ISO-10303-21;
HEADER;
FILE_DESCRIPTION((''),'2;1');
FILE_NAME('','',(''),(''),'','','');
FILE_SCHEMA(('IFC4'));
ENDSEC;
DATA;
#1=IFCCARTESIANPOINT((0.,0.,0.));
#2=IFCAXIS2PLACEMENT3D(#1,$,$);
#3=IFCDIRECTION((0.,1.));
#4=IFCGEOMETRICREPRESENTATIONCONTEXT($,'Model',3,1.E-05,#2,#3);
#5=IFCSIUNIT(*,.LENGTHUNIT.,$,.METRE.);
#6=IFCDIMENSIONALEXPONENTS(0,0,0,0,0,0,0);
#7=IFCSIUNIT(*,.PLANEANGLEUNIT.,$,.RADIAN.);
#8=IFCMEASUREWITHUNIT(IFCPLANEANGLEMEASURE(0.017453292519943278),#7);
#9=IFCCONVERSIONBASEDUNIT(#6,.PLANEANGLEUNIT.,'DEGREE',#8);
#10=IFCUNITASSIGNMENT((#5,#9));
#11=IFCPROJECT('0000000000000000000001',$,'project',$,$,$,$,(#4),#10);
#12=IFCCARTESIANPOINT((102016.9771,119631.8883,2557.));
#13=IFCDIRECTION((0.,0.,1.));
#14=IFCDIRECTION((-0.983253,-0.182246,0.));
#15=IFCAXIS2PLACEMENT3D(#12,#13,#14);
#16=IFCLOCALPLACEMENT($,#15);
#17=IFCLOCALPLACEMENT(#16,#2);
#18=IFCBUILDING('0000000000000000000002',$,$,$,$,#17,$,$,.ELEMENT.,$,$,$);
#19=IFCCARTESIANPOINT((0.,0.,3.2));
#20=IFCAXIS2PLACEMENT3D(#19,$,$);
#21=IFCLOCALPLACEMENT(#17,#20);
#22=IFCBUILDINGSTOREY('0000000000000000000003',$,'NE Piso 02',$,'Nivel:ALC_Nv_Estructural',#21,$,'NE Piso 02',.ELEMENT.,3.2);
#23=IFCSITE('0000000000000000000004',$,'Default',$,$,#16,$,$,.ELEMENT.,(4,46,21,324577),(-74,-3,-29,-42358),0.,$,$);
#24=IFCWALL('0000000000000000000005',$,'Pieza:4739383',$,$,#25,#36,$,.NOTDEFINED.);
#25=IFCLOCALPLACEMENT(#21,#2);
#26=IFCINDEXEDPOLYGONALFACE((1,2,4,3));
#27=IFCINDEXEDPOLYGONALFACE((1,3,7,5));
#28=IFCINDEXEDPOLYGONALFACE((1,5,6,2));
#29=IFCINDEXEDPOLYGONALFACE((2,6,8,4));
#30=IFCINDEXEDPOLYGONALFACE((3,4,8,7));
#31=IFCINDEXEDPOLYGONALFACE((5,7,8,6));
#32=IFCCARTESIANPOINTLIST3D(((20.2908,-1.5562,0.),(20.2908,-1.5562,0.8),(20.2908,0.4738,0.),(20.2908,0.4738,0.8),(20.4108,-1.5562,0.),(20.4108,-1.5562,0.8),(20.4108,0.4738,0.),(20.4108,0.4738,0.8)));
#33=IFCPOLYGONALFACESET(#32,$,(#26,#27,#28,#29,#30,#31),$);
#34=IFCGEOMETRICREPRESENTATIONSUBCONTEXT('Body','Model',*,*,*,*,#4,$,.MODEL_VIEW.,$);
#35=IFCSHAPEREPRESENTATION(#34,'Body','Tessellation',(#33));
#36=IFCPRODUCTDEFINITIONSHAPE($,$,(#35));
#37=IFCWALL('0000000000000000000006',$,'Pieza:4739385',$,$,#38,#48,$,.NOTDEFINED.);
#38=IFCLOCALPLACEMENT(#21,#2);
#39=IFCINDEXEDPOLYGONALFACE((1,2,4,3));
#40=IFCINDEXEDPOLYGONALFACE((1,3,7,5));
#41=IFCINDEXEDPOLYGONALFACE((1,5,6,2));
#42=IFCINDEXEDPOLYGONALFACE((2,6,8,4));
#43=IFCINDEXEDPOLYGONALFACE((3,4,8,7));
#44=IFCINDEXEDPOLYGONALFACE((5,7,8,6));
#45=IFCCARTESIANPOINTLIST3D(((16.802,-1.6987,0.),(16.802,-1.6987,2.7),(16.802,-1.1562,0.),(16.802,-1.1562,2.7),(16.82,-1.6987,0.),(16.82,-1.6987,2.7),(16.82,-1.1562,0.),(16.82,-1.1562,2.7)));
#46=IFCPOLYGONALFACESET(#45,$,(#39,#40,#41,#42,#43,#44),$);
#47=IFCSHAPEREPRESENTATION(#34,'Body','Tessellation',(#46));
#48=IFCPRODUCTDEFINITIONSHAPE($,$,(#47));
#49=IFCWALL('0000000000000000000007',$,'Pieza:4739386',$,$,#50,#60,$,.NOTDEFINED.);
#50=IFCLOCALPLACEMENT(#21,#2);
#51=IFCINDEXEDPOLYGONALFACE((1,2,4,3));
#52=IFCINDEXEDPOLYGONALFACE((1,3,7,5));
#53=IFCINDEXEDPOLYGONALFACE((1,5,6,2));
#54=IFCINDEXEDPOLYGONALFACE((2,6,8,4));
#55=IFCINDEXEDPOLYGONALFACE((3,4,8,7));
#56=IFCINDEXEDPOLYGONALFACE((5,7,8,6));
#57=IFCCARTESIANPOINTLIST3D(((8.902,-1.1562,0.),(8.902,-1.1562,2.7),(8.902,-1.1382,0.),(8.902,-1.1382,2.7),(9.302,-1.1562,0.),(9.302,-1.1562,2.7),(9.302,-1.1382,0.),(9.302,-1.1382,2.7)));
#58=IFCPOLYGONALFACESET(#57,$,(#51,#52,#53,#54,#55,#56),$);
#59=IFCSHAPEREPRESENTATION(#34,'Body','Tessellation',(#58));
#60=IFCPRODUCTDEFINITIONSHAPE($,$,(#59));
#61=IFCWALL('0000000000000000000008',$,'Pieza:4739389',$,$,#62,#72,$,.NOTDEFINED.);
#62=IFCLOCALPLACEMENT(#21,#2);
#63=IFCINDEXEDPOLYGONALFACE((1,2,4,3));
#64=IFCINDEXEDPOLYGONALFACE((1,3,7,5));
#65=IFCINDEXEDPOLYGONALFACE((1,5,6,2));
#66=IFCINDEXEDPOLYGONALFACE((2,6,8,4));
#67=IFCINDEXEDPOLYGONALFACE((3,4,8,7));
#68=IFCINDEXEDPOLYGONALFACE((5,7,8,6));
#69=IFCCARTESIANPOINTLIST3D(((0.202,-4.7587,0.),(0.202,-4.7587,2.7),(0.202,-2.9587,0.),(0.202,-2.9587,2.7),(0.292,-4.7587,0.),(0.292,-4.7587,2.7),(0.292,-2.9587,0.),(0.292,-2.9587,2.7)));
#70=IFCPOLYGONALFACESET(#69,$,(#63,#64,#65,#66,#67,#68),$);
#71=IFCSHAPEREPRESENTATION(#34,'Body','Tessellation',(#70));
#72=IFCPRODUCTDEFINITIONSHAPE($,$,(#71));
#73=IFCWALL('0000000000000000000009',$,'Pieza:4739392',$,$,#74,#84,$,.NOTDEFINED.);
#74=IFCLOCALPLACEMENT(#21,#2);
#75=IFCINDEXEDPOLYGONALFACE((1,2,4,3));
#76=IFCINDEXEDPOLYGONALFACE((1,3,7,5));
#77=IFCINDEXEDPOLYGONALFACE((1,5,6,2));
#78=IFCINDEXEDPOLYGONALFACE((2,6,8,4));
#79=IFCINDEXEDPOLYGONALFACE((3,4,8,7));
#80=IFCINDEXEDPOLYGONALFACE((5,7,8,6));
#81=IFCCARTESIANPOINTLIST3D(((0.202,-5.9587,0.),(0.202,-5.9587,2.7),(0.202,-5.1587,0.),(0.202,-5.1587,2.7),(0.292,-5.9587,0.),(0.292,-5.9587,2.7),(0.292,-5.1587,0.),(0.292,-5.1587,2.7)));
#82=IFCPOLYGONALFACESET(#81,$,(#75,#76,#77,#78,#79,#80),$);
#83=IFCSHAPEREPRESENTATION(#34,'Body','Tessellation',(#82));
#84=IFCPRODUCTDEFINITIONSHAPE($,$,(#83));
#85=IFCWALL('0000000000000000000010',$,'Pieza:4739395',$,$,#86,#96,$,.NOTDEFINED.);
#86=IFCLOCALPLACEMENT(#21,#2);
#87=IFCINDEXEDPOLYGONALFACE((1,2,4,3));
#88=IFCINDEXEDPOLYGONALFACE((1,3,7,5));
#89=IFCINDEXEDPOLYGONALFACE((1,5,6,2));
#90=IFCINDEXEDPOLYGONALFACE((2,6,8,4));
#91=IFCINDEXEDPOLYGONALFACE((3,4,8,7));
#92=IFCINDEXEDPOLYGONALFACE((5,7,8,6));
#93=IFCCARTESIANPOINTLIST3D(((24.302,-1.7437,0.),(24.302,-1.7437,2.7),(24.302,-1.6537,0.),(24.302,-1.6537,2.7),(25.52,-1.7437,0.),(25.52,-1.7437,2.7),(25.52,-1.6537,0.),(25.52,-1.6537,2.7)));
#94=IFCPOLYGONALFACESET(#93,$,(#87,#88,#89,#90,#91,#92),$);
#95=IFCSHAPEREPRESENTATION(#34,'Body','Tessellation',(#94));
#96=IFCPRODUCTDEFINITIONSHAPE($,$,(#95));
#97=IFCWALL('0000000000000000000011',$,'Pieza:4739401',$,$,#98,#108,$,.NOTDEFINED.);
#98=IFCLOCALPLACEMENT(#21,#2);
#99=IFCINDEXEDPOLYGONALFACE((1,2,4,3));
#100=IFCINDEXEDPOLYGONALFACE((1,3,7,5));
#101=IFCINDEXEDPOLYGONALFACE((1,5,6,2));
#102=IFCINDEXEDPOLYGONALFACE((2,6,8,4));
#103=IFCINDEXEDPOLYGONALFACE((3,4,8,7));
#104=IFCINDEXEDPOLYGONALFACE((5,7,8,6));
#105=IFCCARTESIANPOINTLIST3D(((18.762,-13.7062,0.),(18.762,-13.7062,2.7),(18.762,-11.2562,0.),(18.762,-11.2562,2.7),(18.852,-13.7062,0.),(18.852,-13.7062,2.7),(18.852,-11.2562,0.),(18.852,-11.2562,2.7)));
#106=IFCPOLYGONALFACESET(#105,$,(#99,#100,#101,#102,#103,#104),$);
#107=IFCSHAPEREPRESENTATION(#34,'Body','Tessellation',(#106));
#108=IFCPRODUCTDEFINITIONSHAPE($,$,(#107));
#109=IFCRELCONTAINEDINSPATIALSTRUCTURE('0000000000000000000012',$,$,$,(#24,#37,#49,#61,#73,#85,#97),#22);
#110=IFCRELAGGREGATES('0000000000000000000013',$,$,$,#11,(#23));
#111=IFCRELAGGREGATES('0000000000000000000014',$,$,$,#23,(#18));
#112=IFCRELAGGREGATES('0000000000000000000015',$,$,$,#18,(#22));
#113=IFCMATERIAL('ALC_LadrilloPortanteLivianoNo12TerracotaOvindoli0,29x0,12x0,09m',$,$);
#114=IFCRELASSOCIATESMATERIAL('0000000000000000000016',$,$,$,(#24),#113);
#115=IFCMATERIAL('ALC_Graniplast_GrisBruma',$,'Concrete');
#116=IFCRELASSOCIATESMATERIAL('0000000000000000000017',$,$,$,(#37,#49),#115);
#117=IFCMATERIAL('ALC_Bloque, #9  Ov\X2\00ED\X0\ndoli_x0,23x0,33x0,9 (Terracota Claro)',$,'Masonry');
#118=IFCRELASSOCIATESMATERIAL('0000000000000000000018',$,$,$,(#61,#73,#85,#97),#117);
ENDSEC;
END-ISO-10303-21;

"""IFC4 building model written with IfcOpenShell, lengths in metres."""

from ifc_helpers import new_model, entity, si_unit, converted_unit, direction, frame, frame_2d, origin, origin_2d_with_axis, place, context, subcontext, project, spatial, rectangle, extrude, material, element, save


model = new_model("IFC4")

# Units and contexts
model_context = context("Model", 3, precision=1e-05, world=origin(), true_north=direction((0.0, 1.0)))
body_context = subcontext(model_context, "Body", "Model", "MODEL_VIEW")
ifc_project = project(units=[si_unit("LENGTHUNIT", "METRE"), converted_unit("PLANEANGLEUNIT", "DEGREE", entity("IfcPlaneAngleMeasure", 0.017453292519943278), si_unit("PLANEANGLEUNIT", "RADIAN"), dimensions=[0, 0, 0, 0, 0, 0, 0])], contexts=[model_context])

# Site, building, storey
site_placement = place(None, frame((102016.9771, 119631.8883, 2557.0), z_axis=(0.0, 0.0, 1.0), x_axis=(-0.983253, -0.182246, 0.0)))
site = spatial("IfcSite", under=ifc_project, at=site_placement, Name="Default", CompositionType="ELEMENT", RefLatitude=(4, 46, 21, 324577), RefLongitude=(-74, -3, -29, -42358), RefElevation=0.0)
building_placement = place(site_placement, origin())
building = spatial("IfcBuilding", under=site, at=building_placement, CompositionType="ELEMENT")
storey_placement = place(building_placement, frame((0.0, 0.0, 3.2)))
storey = spatial("IfcBuildingStorey", under=building, at=storey_placement, Name="NE Piso 02", ObjectType="Nivel:ALC_Nv_Estructural", LongName="NE Piso 02", CompositionType="ELEMENT", Elevation=3.2)

# Shared definitions
ifc_material_1 = material(Name="ALC_Bloque, #9  Ovíndoli_x0,23x0,33x0,9 (Terracota Claro)", Category="Masonry")

# Shared definitions
ifc_material_2 = material(Name="ALC_Graniplast_GrisBruma", Category="Concrete")

# Walls
ifc_material_3 = material(Name="ALC_LadrilloPortanteLivianoNo12TerracotaOvindoli0,29x0,12x0,09m")
wall_1_placement = place(storey_placement, origin())
element("IfcWall", 1, at=wall_1_placement, inside=storey, material=ifc_material_3, Name="Pieza:4739383", PredefinedType="NOTDEFINED", context=body_context, shape_type="SweptSolid", body=[
    extrude(rectangle(XDim=2.03, YDim=0.12, at=origin_2d_with_axis()), frame((20.3508, -0.5412, 0.0), z_axis=(0.0, 0.0, 1.0), x_axis=(0.0, -1.0, 0.0)), (0.0, 0.0, 1.0), 0.8),
])
wall_2_placement = place(storey_placement, origin())
element("IfcWall", 2, at=wall_2_placement, inside=storey, material=ifc_material_2, Name="Pieza:4739385", PredefinedType="NOTDEFINED", context=body_context, shape_type="SweptSolid", body=[
    extrude(rectangle(XDim=0.5425, YDim=0.018, at=frame_2d((0.0, 0.0), x_axis=(1.0, 0.0))), frame((16.811, -1.4274, 0.0), z_axis=(0.0, 0.0, 1.0), x_axis=(0.0, -1.0, 0.0)), (0.0, 0.0, 1.0), 2.7),
])
wall_3_placement = place(storey_placement, origin())
element("IfcWall", 3, at=wall_3_placement, inside=storey, material=ifc_material_2, Name="Pieza:4739386", PredefinedType="NOTDEFINED", context=body_context, shape_type="SweptSolid", body=[
    extrude(rectangle(XDim=0.018, YDim=0.4, at=frame_2d((0.0, 0.0), x_axis=(1.0, 0.0))), frame((9.102, -1.1472, 0.0), z_axis=(0.0, 0.0, 1.0), x_axis=(0.0, -1.0, 0.0)), (0.0, 0.0, 1.0), 2.7),
])
wall_4_placement = place(storey_placement, origin())
element("IfcWall", 4, at=wall_4_placement, inside=storey, material=ifc_material_1, Name="Pieza:4739389", PredefinedType="NOTDEFINED", context=body_context, shape_type="SweptSolid", body=[
    extrude(rectangle(XDim=1.8, YDim=0.09, at=origin_2d_with_axis()), frame((0.247, -3.8587, 0.0), z_axis=(0.0, 0.0, 1.0), x_axis=(0.0, -1.0, 0.0)), (0.0, 0.0, 1.0), 2.7),
])
wall_5_placement = place(storey_placement, origin())
element("IfcWall", 5, at=wall_5_placement, inside=storey, material=ifc_material_1, Name="Pieza:4739392", PredefinedType="NOTDEFINED", context=body_context, shape_type="SweptSolid", body=[
    extrude(rectangle(XDim=0.8, YDim=0.09, at=origin_2d_with_axis()), frame((0.247, -5.5587, 0.0), z_axis=(0.0, 0.0, 1.0), x_axis=(0.0, -1.0, 0.0)), (0.0, 0.0, 1.0), 2.7),
])
wall_6_placement = place(storey_placement, origin())
element("IfcWall", 6, at=wall_6_placement, inside=storey, material=ifc_material_1, Name="Pieza:4739395", PredefinedType="NOTDEFINED", context=body_context, shape_type="SweptSolid", body=[
    extrude(rectangle(XDim=0.09, YDim=1.218, at=frame_2d((0.0, 0.0), x_axis=(1.0, 0.0))), frame((24.911, -1.6987, 0.0), z_axis=(0.0, 0.0, 1.0), x_axis=(0.0, -1.0, 0.0)), (0.0, 0.0, 1.0), 2.7),
])
wall_7_placement = place(storey_placement, origin())
element("IfcWall", 7, at=wall_7_placement, inside=storey, material=ifc_material_1, Name="Pieza:4739401", PredefinedType="NOTDEFINED", context=body_context, shape_type="SweptSolid", body=[
    extrude(rectangle(XDim=2.45, YDim=0.09, at=frame_2d((0.0, 0.0), x_axis=(1.0, 0.0))), frame((18.807, -12.4812, 0.0), z_axis=(0.0, 0.0, 1.0), x_axis=(0.0, -1.0, 0.0)), (0.0, 0.0, 1.0), 2.7),
])

save(model, "model.ifc")
